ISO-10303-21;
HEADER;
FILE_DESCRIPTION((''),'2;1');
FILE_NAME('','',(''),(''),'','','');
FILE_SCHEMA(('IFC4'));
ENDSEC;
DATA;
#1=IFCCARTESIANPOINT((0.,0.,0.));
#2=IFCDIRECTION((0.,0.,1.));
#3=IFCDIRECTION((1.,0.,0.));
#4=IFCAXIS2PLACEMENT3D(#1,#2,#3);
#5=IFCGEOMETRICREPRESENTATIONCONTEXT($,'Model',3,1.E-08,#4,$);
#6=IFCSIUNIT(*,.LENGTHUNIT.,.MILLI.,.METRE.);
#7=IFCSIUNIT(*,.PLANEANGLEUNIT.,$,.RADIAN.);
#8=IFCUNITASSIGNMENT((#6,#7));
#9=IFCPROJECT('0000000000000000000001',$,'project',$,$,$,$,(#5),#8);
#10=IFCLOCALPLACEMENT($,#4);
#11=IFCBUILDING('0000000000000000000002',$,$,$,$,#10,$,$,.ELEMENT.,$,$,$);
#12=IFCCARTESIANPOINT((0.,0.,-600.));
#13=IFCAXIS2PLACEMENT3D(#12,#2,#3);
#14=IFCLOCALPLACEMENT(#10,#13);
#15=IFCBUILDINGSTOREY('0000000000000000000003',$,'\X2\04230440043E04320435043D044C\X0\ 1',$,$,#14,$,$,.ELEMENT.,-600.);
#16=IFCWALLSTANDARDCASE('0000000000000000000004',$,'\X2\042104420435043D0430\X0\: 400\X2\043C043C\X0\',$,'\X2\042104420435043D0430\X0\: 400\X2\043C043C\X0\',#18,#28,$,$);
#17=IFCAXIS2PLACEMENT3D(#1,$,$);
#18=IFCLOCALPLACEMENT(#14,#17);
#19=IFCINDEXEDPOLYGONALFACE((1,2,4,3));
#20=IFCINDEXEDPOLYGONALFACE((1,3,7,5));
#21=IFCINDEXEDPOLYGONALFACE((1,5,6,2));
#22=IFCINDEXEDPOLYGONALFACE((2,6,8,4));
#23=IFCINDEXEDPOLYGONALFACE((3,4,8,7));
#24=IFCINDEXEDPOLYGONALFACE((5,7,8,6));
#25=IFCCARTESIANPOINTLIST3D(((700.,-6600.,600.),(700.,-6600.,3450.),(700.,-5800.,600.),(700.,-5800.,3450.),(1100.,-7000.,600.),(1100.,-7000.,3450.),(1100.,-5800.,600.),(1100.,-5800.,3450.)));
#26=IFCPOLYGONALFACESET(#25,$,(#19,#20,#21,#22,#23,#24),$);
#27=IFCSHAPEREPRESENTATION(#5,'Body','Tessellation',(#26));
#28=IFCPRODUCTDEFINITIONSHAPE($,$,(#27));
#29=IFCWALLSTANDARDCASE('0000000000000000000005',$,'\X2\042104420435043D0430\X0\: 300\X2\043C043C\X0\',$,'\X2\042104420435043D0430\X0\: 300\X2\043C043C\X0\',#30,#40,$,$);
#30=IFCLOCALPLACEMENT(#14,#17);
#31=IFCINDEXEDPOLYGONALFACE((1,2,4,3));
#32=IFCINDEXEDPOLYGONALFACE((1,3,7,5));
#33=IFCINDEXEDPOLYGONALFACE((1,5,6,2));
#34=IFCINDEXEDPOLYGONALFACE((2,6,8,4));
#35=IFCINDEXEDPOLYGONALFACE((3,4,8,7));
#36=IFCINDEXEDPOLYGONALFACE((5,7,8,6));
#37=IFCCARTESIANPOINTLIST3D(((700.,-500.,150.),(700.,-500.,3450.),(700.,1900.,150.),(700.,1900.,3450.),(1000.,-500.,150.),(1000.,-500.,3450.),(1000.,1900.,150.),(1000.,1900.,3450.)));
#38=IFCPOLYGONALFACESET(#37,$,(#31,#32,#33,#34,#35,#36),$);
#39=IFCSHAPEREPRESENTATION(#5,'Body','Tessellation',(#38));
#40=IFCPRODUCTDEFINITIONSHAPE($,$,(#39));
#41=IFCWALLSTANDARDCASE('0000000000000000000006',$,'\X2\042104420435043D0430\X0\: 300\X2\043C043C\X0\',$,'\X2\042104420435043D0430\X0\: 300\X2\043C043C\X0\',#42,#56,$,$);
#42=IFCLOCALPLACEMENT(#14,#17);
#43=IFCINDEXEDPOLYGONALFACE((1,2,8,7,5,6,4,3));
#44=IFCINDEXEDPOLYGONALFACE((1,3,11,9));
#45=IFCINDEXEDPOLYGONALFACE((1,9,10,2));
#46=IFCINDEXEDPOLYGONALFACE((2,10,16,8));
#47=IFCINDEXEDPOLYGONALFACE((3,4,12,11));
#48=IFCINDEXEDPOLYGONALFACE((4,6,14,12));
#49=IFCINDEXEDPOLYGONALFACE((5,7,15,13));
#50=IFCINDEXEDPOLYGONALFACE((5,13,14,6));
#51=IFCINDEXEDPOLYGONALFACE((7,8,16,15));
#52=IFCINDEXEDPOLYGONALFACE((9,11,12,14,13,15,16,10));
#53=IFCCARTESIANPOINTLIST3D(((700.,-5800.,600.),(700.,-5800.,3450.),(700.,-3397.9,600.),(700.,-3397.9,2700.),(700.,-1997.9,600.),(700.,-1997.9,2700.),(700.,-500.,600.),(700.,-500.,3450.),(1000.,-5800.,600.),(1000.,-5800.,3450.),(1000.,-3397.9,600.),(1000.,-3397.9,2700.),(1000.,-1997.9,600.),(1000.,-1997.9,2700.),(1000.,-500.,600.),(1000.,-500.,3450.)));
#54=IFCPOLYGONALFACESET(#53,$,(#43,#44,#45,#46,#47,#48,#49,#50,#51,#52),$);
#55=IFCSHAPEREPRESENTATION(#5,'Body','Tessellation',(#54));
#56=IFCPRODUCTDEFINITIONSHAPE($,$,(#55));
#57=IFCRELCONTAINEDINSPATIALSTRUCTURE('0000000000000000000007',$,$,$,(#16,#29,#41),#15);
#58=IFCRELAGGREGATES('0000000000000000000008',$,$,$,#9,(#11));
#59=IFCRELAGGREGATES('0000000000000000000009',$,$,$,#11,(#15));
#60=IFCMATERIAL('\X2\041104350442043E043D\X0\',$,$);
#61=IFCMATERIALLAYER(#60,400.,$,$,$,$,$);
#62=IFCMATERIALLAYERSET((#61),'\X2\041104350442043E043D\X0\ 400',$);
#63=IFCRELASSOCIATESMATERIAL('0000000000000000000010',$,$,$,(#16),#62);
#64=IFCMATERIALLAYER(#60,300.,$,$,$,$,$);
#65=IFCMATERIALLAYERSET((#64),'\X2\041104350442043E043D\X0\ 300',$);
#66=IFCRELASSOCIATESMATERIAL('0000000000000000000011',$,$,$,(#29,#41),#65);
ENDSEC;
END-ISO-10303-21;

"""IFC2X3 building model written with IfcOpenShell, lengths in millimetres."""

from ifc_helpers import new_model, si_unit, frame, frame_2d, origin_with_axes, place, context, project, spatial, polyline, segment, composite_curve, rectangle, outline, extrude, material, layer, layer_set, layer_usage, element, save


model = new_model("IFC2X3")

# Units and contexts
model_context = context("Model", 3, precision=1e-08, world=origin_with_axes())
ifc_project = project(units=[si_unit("LENGTHUNIT", "METRE", prefix="MILLI"), si_unit("PLANEANGLEUNIT", "RADIAN")], contexts=[model_context])

# Building, storey
building_placement = place(None, origin_with_axes())
building = spatial("IfcBuilding", under=ifc_project, at=building_placement, CompositionType="ELEMENT")
storey_placement = place(building_placement, frame((0.0, 0.0, -600.0), z_axis=(0.0, 0.0, 1.0), x_axis=(1.0, 0.0, 0.0)))
storey = spatial("IfcBuildingStorey", under=building, at=storey_placement, Name="Уровень 1", CompositionType="ELEMENT", Elevation=-600.0)

# Shared definitions
ifc_material_1 = material(Name="Бетон")

# Shared definitions
ifc_layer_1 = layer(ifc_material_1, 400.0)
ifc_layer_set_1 = layer_set([ifc_layer_1], Name="Бетон 400")

# Walls
ifc_layer_usage_1 = layer_usage(ifc_layer_set_1, "AXIS2", "NEGATIVE", 0.0)
wall_1_placement = place(storey_placement, frame((700.0, -7000.0, 600.0), z_axis=(0.0, 0.0, 1.0), x_axis=(0.0, 1.0, 0.0)))
element("IfcWallStandardCase", 1, at=wall_1_placement, inside=storey, material=ifc_layer_usage_1, Name="Стена: 400мм", ObjectType="Стена: 400мм", context=model_context, shape_type="SweptSolid", body=[
    extrude(outline(composite_curve([segment(polyline([(0.0, -400.0), (1200.0, -400.0)]), True, "CONTINUOUS"), segment(polyline([(1200.0, -400.0), (1200.0, 0.0)]), True, "CONTINUOUS"), segment(polyline([(1200.0, 0.0), (400.0, 0.0)]), True, "CONTINUOUS"), segment(polyline([(400.0, 0.0), (0.0, -400.0)]), True, "CONTINUOUS")], self_intersect=False)), origin_with_axes(), (0.0, 0.0, 1.0), 2850.0),
])
ifc_layer_2 = layer(ifc_material_1, 300.0)
ifc_layer_set_2 = layer_set([ifc_layer_2], Name="Бетон 300")
ifc_layer_usage_2 = layer_usage(ifc_layer_set_2, "AXIS2", "NEGATIVE", 300.0)
wall_2_placement = place(storey_placement, frame((700.0, 1900.0, 150.0), z_axis=(0.0, 0.0, 1.0), x_axis=(0.0, -1.0, 0.0)))
element("IfcWallStandardCase", 2, at=wall_2_placement, inside=storey, material=ifc_layer_usage_2, Name="Стена: 300мм", ObjectType="Стена: 300мм", context=model_context, shape_type="SweptSolid", body=[
    extrude(outline(composite_curve([segment(polyline([(0.0, 0.0), (2400.0, 0.0)]), True, "CONTINUOUS"), segment(polyline([(2400.0, 0.0), (2400.0, 300.0)]), True, "CONTINUOUS"), segment(polyline([(2400.0, 300.0), (0.0, 300.0)]), True, "CONTINUOUS"), segment(polyline([(0.0, 300.0), (0.0, 0.0)]), True, "CONTINUOUS")], self_intersect=False)), origin_with_axes(), (0.0, 0.0, 1.0), 3300.0),
])

# Wall, opening
ifc_layer_usage_3 = layer_usage(ifc_layer_set_2, "AXIS2", "NEGATIVE", 0.0)
wall_3_placement = place(storey_placement, frame((700.0, -5800.0, 600.0), z_axis=(0.0, 0.0, 1.0), x_axis=(0.0, 1.0, 0.0)))
wall_3 = element("IfcWallStandardCase", 3, at=wall_3_placement, inside=storey, material=ifc_layer_usage_3, Name="Стена: 300мм", ObjectType="Стена: 300мм", context=model_context, shape_type="SweptSolid", body=[
    extrude(outline(composite_curve([segment(polyline([(0.0, -300.0), (5300.0, -300.0)]), True, "CONTINUOUS"), segment(polyline([(5300.0, -300.0), (5300.0, 0.0)]), True, "CONTINUOUS"), segment(polyline([(5300.0, 0.0), (0.0, 0.0)]), True, "CONTINUOUS"), segment(polyline([(0.0, 0.0), (0.0, -300.0)]), True, "CONTINUOUS")], self_intersect=False)), origin_with_axes(), (0.0, 0.0, 1.0), 2850.0),
])
opening_1_placement = place(wall_3_placement, frame((3802.1, 0.0, 0.0), z_axis=(0.0, 0.0, 1.0), x_axis=(-1.0, 0.0, 0.0)))
element("IfcOpeningElement", 4, at=opening_1_placement, cuts=wall_3, ObjectType="Opening", context=model_context, shape_type="SweptSolid", body=[
    extrude(rectangle(XDim=1400.0, YDim=2100.0, at=frame_2d((700.0, 1050.0), x_axis=(1.0, 0.0))), frame((0.0, -5.0, 0.0), z_axis=(0.0, -1.0, 0.0), x_axis=(1.0, 0.0, 0.0)), (0.0, 0.0, -1.0), 310.0),
])

save(model, "model.ifc")
